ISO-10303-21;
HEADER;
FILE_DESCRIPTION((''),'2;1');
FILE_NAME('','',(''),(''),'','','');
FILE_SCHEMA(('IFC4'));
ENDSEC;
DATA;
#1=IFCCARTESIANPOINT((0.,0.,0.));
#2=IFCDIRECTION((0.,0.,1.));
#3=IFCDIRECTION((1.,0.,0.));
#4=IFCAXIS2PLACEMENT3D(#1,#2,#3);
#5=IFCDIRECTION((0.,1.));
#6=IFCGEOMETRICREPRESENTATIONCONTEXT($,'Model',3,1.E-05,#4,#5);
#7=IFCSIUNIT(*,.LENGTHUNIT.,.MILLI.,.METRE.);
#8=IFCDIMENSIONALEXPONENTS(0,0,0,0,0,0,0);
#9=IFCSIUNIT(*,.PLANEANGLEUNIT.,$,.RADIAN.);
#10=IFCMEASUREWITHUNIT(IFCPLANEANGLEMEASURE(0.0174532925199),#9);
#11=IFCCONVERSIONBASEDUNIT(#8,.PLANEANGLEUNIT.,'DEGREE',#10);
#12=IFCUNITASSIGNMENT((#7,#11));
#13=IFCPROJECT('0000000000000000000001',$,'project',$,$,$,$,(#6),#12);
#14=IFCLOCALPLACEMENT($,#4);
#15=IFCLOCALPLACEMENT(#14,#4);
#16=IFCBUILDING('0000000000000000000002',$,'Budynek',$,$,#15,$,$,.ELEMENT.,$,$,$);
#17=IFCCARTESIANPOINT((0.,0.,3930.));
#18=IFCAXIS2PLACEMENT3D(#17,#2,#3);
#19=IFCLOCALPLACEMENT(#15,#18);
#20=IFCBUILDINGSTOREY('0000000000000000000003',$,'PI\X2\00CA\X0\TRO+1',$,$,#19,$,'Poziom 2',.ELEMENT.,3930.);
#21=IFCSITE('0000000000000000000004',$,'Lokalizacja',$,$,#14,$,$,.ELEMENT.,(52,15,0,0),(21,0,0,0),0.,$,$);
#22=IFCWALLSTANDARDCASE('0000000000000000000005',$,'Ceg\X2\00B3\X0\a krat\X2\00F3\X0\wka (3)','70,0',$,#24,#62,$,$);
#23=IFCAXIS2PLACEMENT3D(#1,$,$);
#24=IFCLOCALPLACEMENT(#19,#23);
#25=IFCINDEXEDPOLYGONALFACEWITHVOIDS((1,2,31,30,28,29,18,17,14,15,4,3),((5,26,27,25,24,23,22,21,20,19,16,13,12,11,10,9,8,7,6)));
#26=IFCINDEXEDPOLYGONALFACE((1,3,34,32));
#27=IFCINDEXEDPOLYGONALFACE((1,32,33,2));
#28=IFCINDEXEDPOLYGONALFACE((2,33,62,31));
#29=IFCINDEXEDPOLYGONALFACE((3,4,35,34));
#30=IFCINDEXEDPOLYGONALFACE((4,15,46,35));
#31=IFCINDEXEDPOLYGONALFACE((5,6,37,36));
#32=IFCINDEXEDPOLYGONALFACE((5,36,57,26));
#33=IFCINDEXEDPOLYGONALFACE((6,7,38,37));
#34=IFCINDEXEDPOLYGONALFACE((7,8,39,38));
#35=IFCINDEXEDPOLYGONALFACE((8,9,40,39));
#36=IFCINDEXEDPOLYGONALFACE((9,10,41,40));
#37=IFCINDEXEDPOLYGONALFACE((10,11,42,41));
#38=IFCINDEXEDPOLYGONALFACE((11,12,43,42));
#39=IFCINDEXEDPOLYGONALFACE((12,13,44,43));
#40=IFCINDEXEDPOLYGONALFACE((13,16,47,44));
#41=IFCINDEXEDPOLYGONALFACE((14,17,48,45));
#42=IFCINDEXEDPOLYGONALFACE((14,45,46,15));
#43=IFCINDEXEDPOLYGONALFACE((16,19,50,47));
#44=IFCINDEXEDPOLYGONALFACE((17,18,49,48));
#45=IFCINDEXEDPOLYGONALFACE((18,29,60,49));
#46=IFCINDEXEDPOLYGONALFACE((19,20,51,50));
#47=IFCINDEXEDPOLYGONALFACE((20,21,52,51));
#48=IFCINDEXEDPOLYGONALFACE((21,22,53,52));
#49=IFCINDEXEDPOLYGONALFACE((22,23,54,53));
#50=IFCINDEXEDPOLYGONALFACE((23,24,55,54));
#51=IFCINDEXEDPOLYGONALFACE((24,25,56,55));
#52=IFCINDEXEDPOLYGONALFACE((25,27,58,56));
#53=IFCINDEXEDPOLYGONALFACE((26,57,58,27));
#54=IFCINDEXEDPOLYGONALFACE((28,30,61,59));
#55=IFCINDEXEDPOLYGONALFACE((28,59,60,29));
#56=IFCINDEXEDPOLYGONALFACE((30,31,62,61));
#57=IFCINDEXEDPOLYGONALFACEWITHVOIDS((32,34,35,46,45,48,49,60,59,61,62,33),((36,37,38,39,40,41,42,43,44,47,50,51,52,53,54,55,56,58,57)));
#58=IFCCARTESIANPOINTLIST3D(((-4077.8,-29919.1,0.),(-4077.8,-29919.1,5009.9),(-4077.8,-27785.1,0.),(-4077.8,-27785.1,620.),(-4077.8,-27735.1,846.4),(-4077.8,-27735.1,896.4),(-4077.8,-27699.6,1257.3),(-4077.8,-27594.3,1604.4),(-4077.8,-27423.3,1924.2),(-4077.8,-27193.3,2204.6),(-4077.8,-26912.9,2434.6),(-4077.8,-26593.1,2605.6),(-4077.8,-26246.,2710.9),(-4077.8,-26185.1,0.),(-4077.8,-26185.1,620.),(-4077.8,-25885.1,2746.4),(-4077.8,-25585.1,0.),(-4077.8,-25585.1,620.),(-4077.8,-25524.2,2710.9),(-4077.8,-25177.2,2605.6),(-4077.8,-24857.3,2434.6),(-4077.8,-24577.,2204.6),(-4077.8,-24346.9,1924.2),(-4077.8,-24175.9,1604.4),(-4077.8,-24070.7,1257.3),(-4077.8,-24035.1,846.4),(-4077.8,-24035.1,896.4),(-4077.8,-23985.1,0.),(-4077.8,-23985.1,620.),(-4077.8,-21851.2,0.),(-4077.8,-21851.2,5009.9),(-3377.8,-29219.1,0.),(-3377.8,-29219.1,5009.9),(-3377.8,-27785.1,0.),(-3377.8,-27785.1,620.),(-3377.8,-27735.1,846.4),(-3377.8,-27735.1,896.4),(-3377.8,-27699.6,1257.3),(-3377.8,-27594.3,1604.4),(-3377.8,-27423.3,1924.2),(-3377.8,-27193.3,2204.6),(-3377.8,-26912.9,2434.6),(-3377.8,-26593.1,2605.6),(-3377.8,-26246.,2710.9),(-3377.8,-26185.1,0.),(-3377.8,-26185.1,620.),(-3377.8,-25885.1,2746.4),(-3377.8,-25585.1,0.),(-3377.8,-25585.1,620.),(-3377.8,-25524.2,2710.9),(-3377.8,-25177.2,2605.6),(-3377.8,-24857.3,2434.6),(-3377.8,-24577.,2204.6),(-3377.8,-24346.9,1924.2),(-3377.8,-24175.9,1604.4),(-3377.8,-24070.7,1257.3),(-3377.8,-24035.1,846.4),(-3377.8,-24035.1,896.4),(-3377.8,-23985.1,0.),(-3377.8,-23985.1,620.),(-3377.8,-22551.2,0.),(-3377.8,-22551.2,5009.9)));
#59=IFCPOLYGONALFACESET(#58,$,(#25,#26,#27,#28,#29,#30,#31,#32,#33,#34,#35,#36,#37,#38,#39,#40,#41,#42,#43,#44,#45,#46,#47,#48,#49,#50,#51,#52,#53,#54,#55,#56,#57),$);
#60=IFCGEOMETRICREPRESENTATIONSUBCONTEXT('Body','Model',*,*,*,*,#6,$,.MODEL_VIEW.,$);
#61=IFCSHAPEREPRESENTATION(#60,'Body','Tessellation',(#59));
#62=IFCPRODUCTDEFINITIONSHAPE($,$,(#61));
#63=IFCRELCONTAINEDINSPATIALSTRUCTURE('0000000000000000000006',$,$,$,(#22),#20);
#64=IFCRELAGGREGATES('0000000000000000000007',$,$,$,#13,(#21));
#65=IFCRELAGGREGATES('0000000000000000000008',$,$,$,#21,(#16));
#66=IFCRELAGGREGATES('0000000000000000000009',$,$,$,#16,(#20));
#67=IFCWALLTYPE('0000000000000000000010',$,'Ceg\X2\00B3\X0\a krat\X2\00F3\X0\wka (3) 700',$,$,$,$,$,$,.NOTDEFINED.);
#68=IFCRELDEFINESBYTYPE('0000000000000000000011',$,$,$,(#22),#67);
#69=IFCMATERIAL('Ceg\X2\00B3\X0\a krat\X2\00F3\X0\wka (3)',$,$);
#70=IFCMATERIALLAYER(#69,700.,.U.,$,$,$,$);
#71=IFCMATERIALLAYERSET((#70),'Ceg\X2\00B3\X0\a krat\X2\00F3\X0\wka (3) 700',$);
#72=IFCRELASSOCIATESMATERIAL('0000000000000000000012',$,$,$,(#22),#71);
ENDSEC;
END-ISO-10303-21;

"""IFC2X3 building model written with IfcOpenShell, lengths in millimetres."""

from ifc_helpers import new_model, entity, si_unit, converted_unit, direction, frame, origin_with_axes, origin_2d_with_axis, place, context, subcontext, project, spatial, polyline, rectangle, outline, extrude, material, layer, layer_set, layer_usage, type_object, element, save


model = new_model("IFC2X3")

# Units and contexts
model_context = context("Model", 3, precision=1e-05, world=origin_with_axes(), true_north=direction((0.0, 1.0)))
body_context = subcontext(model_context, "Body", "Model", "MODEL_VIEW")
ifc_project = project(units=[si_unit("LENGTHUNIT", "METRE", prefix="MILLI"), converted_unit("PLANEANGLEUNIT", "DEGREE", entity("IfcPlaneAngleMeasure", 0.0174532925199), si_unit("PLANEANGLEUNIT", "RADIAN"), dimensions=[0, 0, 0, 0, 0, 0, 0])], contexts=[model_context])

# Site, building, storey
site_placement = place(None, origin_with_axes())
site = spatial("IfcSite", under=ifc_project, at=site_placement, Name="Lokalizacja", CompositionType="ELEMENT", RefLatitude=(52, 15, 0, 0), RefLongitude=(21, 0, 0, 0), RefElevation=0.0)
building_placement = place(site_placement, origin_with_axes())
building = spatial("IfcBuilding", under=site, at=building_placement, Name="Budynek", CompositionType="ELEMENT")
storey_placement = place(building_placement, frame((0.0, 0.0, 3930.0), z_axis=(0.0, 0.0, 1.0), x_axis=(1.0, 0.0, 0.0)))
storey = spatial("IfcBuildingStorey", under=building, at=storey_placement, Name="PIÊTRO+1", LongName="Poziom 2", CompositionType="ELEMENT", Elevation=3930.0)

# Wall, openings
ifc_material_1 = material(Name="Ceg³a kratówka (3)")
ifc_layer = layer(ifc_material_1, 700.0, ventilated="UNKNOWN")
ifc_layer_set = layer_set([ifc_layer], Name="Ceg³a kratówka (3) 700")
ifc_layer_usage = layer_usage(ifc_layer_set, "AXIS2", "NEGATIVE", 0.0)
wall_type_1 = type_object("IfcWallType", Name="Ceg³a kratówka (3) 700", PredefinedType="NOTDEFINED")
wall_1_placement = place(storey_placement, frame((-3377.8, -22551.2, 0.0), z_axis=(0.0, 0.0, 1.0), x_axis=(0.0, -1.0, 0.0)))
wall_1 = element("IfcWallStandardCase", 1, at=wall_1_placement, inside=storey, type_object=wall_type_1, material=ifc_layer_usage, Name="Ceg³a kratówka (3)", Description="70,0", context=body_context, shape_type="SweptSolid", body=[
    extrude(outline(polyline([(-700.0, -700.0), (7367.9, -700.0), (6667.9, 0.0), (0.0, 0.0), (-700.0, -700.0)])), origin_with_axes(), (0.0, 0.0, 1.0), 5009.9),
])
opening_1_placement = place(wall_1_placement, frame((3334.0, 0.0, 846.4), z_axis=(0.0, 0.0, 1.0), x_axis=(1.0, 0.0, 0.0)))
element("IfcOpeningElement", 2, at=opening_1_placement, cuts=wall_1, context=body_context, shape_type="SweptSolid", body=[
    extrude(outline(polyline([(-1850.0, 0.0), (-1850.0, -50.0), (-1814.5, -410.9), (-1709.2, -758.0), (-1538.2, -1077.8), (-1308.1, -1358.1), (-1027.8, -1588.2), (-708.0, -1759.2), (-360.9, -1864.5), (0.0, -1900.0), (360.9, -1864.5), (708.0, -1759.2), (1027.8, -1588.2), (1308.1, -1358.1), (1538.2, -1077.8), (1709.2, -758.0), (1814.5, -410.9), (1850.0, -50.0), (1850.0, 0.0), (-1850.0, 0.0)])), frame((0.0, 700.0, 0.0), z_axis=(0.0, 1.0, 0.0), x_axis=(1.0, 0.0, 0.0)), (0.0, 0.0, -1.0), 2100.0),
])
opening_2_placement = place(wall_1_placement, frame((2234.0, 0.0, 0.0), z_axis=(0.0, 0.0, 1.0), x_axis=(1.0, 0.0, 0.0)))
element("IfcOpeningElement", 3, at=opening_2_placement, cuts=wall_1, context=body_context, shape_type="SweptSolid", body=[
    extrude(rectangle(XDim=1600.0, YDim=620.0, at=origin_2d_with_axis()), frame((0.0, -700.0, 310.0), z_axis=(0.0, 1.0, 0.0), x_axis=(1.0, 0.0, 0.0)), (0.0, 0.0, -1.0), 700.0),
    extrude(rectangle(XDim=1600.0, YDim=620.0, at=origin_2d_with_axis()), frame((0.0, -700.0, 310.0), z_axis=(0.0, -1.0, 0.0), x_axis=(1.0, 0.0, 0.0)), (0.0, 0.0, -1.0), 700.0),
])
opening_3_placement = place(wall_1_placement, frame((4434.0, 0.0, 0.0), z_axis=(0.0, 0.0, 1.0), x_axis=(1.0, 0.0, 0.0)))
element("IfcOpeningElement", 4, at=opening_3_placement, cuts=wall_1, context=body_context, shape_type="SweptSolid", body=[
    extrude(rectangle(XDim=1600.0, YDim=620.0, at=origin_2d_with_axis()), frame((0.0, -700.0, 310.0), z_axis=(0.0, 1.0, 0.0), x_axis=(1.0, 0.0, 0.0)), (0.0, 0.0, -1.0), 700.0),
    extrude(rectangle(XDim=1600.0, YDim=620.0, at=origin_2d_with_axis()), frame((0.0, -700.0, 310.0), z_axis=(0.0, -1.0, 0.0), x_axis=(1.0, 0.0, 0.0)), (0.0, 0.0, -1.0), 700.0),
])

save(model, "model.ifc")
